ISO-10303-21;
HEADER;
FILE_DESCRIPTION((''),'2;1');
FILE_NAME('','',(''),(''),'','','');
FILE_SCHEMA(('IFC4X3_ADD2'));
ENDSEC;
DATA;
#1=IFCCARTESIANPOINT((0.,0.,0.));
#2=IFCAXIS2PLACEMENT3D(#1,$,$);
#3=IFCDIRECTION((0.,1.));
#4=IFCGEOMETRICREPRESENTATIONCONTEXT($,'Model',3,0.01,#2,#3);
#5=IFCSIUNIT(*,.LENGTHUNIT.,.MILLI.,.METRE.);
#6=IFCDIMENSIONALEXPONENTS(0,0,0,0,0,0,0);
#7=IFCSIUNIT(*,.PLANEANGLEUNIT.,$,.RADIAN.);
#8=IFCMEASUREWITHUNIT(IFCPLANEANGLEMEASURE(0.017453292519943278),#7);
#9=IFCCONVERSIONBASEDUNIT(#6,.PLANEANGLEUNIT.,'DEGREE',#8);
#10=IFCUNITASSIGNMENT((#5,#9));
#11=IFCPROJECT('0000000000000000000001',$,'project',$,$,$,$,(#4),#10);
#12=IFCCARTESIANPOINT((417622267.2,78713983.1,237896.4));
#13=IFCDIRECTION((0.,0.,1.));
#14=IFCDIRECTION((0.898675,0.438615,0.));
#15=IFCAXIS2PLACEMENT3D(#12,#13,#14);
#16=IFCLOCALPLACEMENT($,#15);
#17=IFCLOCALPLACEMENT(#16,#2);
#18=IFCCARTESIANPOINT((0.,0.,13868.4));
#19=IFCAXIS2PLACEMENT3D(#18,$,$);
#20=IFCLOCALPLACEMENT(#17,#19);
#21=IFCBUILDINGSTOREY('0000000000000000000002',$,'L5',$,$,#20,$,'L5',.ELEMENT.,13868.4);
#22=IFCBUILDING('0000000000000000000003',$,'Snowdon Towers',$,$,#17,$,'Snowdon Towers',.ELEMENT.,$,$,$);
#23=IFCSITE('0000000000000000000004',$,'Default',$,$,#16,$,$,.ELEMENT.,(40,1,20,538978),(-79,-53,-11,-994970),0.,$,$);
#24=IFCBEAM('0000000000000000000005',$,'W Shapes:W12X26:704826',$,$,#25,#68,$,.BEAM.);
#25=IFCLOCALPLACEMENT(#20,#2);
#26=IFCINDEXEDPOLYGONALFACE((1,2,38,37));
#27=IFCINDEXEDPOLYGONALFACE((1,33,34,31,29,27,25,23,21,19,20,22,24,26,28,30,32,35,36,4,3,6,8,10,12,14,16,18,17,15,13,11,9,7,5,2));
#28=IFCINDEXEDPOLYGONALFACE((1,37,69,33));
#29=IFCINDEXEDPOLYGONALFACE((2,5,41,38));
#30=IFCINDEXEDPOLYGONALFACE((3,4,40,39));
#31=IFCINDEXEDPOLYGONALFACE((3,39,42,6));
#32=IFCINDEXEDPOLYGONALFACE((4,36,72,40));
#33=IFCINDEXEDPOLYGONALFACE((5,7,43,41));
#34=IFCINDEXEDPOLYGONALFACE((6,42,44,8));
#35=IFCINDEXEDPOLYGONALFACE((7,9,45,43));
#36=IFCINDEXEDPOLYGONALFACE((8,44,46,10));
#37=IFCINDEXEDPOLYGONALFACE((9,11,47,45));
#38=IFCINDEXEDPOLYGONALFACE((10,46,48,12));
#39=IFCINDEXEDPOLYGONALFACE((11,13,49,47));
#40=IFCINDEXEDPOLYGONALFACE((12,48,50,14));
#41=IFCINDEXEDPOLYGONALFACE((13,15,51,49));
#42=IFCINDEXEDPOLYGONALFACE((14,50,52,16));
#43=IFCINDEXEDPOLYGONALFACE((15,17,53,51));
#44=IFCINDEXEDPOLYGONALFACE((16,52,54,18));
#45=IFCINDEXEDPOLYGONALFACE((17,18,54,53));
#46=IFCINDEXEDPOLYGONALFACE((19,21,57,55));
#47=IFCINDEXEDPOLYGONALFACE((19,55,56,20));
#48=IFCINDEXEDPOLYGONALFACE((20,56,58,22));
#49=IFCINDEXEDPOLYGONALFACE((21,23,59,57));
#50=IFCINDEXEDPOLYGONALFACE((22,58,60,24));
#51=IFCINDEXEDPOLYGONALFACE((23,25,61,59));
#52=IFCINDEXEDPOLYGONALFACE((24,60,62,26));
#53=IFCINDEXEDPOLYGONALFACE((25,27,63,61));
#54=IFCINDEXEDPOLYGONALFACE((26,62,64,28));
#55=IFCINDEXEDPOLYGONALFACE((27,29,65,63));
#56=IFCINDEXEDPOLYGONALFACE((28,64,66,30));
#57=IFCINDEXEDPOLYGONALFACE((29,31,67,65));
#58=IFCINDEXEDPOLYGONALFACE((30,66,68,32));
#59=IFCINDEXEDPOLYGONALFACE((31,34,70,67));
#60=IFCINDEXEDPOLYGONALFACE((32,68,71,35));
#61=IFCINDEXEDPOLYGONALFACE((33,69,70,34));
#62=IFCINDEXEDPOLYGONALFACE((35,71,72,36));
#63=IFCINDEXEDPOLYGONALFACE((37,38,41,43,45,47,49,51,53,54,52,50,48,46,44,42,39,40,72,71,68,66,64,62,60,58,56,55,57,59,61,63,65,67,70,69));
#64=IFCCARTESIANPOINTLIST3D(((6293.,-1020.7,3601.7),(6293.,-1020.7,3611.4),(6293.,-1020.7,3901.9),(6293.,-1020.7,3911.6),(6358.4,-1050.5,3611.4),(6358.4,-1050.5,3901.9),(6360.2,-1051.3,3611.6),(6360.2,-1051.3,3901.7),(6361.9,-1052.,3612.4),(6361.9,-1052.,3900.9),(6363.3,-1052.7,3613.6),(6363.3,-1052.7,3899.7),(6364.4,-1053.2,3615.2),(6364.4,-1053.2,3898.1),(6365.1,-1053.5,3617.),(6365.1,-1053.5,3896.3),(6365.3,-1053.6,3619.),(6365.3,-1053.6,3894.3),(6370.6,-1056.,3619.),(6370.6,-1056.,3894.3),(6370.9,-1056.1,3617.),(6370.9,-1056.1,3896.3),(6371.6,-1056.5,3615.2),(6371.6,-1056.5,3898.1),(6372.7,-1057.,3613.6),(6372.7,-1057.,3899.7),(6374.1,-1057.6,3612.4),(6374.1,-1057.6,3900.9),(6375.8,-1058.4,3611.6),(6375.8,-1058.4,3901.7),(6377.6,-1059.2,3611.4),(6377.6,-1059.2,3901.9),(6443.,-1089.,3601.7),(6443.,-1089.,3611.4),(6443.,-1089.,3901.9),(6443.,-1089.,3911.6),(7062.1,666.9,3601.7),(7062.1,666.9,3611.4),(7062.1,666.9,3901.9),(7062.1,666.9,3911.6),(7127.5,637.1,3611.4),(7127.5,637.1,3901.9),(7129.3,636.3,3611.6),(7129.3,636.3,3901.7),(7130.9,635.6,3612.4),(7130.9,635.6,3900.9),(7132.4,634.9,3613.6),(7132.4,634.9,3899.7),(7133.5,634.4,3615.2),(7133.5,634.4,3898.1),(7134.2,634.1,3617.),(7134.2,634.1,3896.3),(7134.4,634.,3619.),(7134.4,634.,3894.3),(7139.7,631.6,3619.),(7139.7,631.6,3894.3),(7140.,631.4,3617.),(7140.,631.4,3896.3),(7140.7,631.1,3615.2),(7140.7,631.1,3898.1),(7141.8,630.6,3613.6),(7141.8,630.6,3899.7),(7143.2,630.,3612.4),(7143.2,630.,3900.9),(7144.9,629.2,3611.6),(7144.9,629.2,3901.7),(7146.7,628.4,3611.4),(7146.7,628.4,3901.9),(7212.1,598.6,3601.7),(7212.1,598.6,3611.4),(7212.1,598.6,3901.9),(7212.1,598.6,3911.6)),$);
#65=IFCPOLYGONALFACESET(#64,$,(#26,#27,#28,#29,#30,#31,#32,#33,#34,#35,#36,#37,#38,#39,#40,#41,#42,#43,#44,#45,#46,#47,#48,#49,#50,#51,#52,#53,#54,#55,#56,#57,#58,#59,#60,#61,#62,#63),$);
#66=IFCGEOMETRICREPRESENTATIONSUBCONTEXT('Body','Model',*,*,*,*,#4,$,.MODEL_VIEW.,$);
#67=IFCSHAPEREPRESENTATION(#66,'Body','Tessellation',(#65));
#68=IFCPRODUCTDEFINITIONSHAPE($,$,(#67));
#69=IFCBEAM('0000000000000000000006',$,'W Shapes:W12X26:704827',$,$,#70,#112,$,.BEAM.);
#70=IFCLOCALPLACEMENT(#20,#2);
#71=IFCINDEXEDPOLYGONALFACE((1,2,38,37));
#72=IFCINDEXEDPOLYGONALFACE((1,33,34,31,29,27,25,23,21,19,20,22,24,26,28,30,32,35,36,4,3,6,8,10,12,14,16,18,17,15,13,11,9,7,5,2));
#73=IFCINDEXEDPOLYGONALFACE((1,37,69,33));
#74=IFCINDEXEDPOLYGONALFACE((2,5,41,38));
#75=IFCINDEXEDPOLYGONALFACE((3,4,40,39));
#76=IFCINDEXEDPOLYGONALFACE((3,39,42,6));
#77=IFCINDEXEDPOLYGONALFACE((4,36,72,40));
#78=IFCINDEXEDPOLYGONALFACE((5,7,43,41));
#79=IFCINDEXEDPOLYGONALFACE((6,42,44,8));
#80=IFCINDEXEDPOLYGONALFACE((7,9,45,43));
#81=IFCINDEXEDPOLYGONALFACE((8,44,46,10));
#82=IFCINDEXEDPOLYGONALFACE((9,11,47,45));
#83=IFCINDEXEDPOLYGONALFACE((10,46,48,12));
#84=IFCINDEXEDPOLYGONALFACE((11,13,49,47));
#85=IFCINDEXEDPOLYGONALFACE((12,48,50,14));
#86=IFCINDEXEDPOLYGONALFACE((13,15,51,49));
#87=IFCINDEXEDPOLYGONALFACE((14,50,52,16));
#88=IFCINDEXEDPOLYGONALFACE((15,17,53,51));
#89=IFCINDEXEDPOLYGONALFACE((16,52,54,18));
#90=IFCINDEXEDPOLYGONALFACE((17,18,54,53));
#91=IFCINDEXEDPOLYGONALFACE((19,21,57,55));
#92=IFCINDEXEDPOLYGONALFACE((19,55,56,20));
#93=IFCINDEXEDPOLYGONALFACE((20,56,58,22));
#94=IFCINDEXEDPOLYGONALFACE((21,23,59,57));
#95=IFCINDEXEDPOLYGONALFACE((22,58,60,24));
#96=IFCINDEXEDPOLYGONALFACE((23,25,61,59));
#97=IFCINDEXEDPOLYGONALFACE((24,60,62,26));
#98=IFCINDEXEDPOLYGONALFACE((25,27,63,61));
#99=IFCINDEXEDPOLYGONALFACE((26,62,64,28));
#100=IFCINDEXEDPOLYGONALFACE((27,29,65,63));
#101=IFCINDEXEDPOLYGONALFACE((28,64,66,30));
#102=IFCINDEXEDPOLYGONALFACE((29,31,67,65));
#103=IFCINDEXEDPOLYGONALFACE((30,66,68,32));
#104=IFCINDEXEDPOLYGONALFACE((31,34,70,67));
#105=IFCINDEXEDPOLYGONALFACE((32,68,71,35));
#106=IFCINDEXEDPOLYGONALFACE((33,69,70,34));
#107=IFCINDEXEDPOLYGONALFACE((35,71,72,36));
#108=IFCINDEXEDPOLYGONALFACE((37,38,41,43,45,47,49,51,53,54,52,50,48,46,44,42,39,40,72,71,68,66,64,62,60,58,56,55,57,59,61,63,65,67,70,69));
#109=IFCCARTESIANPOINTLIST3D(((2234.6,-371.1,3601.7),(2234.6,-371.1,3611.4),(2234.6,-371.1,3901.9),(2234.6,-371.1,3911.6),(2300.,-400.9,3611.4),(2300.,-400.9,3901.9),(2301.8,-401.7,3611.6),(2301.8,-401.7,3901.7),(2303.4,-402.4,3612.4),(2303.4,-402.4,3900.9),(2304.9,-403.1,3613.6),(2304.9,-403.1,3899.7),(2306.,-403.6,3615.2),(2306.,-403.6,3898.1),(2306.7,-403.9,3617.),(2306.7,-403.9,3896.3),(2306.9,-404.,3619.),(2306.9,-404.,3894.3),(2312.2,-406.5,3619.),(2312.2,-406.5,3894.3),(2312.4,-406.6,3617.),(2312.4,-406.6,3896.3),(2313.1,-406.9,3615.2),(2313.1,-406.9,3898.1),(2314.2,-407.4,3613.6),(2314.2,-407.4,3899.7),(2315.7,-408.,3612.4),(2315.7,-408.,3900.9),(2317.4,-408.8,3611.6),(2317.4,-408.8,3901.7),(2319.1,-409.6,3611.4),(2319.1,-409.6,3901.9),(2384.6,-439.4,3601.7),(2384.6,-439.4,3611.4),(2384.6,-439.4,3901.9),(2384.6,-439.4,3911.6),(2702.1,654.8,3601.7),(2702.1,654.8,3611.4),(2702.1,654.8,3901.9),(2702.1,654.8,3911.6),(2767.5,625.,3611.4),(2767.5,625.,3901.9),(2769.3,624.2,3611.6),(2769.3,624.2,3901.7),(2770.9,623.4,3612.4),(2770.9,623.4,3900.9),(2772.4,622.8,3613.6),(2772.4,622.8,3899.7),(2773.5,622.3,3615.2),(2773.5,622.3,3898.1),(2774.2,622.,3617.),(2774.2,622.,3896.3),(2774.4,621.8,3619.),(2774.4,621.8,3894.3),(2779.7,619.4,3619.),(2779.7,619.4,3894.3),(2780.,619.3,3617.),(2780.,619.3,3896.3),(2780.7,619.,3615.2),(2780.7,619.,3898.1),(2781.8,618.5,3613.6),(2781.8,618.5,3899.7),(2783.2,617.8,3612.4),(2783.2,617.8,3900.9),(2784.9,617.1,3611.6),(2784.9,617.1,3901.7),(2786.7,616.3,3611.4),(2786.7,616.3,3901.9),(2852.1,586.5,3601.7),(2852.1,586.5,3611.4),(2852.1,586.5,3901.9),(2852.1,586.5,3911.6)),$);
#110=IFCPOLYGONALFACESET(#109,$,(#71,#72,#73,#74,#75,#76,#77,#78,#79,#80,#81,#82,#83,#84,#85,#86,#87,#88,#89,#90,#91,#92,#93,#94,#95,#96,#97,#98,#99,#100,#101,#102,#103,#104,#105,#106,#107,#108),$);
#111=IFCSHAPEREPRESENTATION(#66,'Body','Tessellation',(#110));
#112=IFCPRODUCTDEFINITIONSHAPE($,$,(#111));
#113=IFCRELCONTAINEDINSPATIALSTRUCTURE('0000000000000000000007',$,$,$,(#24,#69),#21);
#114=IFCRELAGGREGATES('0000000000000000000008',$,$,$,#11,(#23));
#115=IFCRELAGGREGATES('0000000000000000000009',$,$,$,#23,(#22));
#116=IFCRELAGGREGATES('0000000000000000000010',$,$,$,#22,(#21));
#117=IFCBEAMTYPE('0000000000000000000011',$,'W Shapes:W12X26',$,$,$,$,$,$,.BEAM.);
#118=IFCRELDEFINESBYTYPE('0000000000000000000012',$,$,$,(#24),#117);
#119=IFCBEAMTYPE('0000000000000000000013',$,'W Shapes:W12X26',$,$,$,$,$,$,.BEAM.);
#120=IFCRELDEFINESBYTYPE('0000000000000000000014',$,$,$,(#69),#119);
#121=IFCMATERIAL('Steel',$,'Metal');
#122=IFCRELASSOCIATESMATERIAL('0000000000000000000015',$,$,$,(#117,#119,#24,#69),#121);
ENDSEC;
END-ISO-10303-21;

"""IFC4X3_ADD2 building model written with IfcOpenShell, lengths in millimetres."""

from ifc_helpers import new_model, entity, si_unit, converted_unit, direction, frame, frame_2d, origin, place, context, subcontext, project, spatial, polyline, circle_curve, parameter, trimmed, segment, composite_curve, outline, extrude, source, transform, mapped, material, material_profile, profile_set, profile_usage, type_object, type_shapes, element, save


model = new_model("IFC4X3_ADD2")

# Units and contexts
model_context = context("Model", 3, precision=0.01, world=origin(), true_north=direction((0.0, 1.0)))
body_context = subcontext(model_context, "Body", "Model", "MODEL_VIEW")
ifc_project = project(units=[si_unit("LENGTHUNIT", "METRE", prefix="MILLI"), converted_unit("PLANEANGLEUNIT", "DEGREE", entity("IfcPlaneAngleMeasure", 0.017453292519943278), si_unit("PLANEANGLEUNIT", "RADIAN"), dimensions=[0, 0, 0, 0, 0, 0, 0])], contexts=[model_context])

# Site, building, storey
site_placement = place(None, frame((417622267.2, 78713983.1, 237896.4), z_axis=(0.0, 0.0, 1.0), x_axis=(0.898675, 0.438615, 0.0)))
site = spatial("IfcSite", under=ifc_project, at=site_placement, Name="Default", CompositionType="ELEMENT", RefLatitude=(40, 1, 20, 538978), RefLongitude=(-79, -53, -11, -994970), RefElevation=0.0)
building_placement = place(site_placement, origin())
building = spatial("IfcBuilding", under=site, at=building_placement, Name="Snowdon Towers", LongName="Snowdon Towers", CompositionType="ELEMENT")
storey_placement = place(building_placement, frame((0.0, 0.0, 13868.4)))
storey = spatial("IfcBuildingStorey", under=building, at=storey_placement, Name="L5", LongName="L5", CompositionType="ELEMENT", Elevation=13868.4)

# Shared definitions
ifc_material_1 = material(Name="Steel", Category="Metal")

# Beams
ifc_material_profile_1 = material_profile(ifc_material_1, outline(composite_curve([segment(polyline([(-82.4, -145.3), (-82.4, -154.9)]), True, "CONTINUOUS"), segment(polyline([(-82.4, -154.9), (82.4, -154.9)]), True, "CONTINUOUS"), segment(polyline([(82.4, -154.9), (82.4, -145.3)]), True, "CONTINUOUS"), segment(polyline([(82.4, -145.3), (10.5, -145.3)]), True, "CONTINUOUS"), segment(trimmed(circle_curve(frame_2d((10.5, -137.7), x_axis=(1.0, 0.0)), 7.6), [parameter(180.0)], [parameter(270.0)], True, "PARAMETER"), False, "CONTINUOUS"), segment(polyline([(2.9, -137.7), (2.9, 137.7)]), True, "CONTINUOUS"), segment(trimmed(circle_curve(frame_2d((10.5, 137.7), x_axis=(1.0, 0.0)), 7.6), [parameter(90.0)], [parameter(180.0)], True, "PARAMETER"), False, "CONTINUOUS"), segment(polyline([(10.5, 145.3), (82.4, 145.3)]), True, "CONTINUOUS"), segment(polyline([(82.4, 145.3), (82.4, 154.9)]), True, "CONTINUOUS"), segment(polyline([(82.4, 154.9), (-82.4, 154.9)]), True, "CONTINUOUS"), segment(polyline([(-82.4, 154.9), (-82.4, 145.3)]), True, "CONTINUOUS"), segment(polyline([(-82.4, 145.3), (-10.5, 145.3)]), True, "CONTINUOUS"), segment(trimmed(circle_curve(frame_2d((-10.5, 137.7), x_axis=(1.0, 0.0)), 7.6), [parameter(360.0)], [parameter(90.0)], True, "PARAMETER"), False, "CONTINUOUS"), segment(polyline([(-2.9, 137.7), (-2.9, -137.7)]), True, "CONTINUOUS"), segment(trimmed(circle_curve(frame_2d((-10.5, -137.7), x_axis=(1.0, 0.0)), 7.6), [parameter(270.0)], [parameter(360.0)], True, "PARAMETER"), False, "CONTINUOUS"), segment(polyline([(-10.5, -145.3), (-82.4, -145.3)]), True, "CONTINUOUS")], self_intersect=False)), Name="W12X26")
ifc_profile_set_1 = profile_set([ifc_material_profile_1], Name="W12X26")
ifc_profile_usage_1 = profile_usage(ifc_profile_set_1, cardinal=8)
beam_type_1 = type_object("IfcBeamType", Name="W Shapes:W12X26", PredefinedType="BEAM", material=ifc_profile_set_1)
shared_shape_1 = source(origin(), body_context, "Body", "SweptSolid", [
    extrude(outline(composite_curve([segment(polyline([(-82.4, -145.3), (-82.4, -154.9)]), True, "CONTINUOUS"), segment(polyline([(-82.4, -154.9), (82.4, -154.9)]), True, "CONTINUOUS"), segment(polyline([(82.4, -154.9), (82.4, -145.3)]), True, "CONTINUOUS"), segment(polyline([(82.4, -145.3), (10.5, -145.3)]), True, "CONTINUOUS"), segment(trimmed(circle_curve(frame_2d((10.5, -137.7), x_axis=(1.0, 0.0)), 7.6), [parameter(180.0)], [parameter(270.0)], True, "PARAMETER"), False, "CONTINUOUS"), segment(polyline([(2.9, -137.7), (2.9, 137.7)]), True, "CONTINUOUS"), segment(trimmed(circle_curve(frame_2d((10.5, 137.7), x_axis=(1.0, 0.0)), 7.6), [parameter(90.0)], [parameter(180.0)], True, "PARAMETER"), False, "CONTINUOUS"), segment(polyline([(10.5, 145.3), (82.4, 145.3)]), True, "CONTINUOUS"), segment(polyline([(82.4, 145.3), (82.4, 154.9)]), True, "CONTINUOUS"), segment(polyline([(82.4, 154.9), (-82.4, 154.9)]), True, "CONTINUOUS"), segment(polyline([(-82.4, 154.9), (-82.4, 145.3)]), True, "CONTINUOUS"), segment(polyline([(-82.4, 145.3), (-10.5, 145.3)]), True, "CONTINUOUS"), segment(trimmed(circle_curve(frame_2d((-10.5, 137.7), x_axis=(1.0, 0.0)), 7.6), [parameter(360.0)], [parameter(90.0)], True, "PARAMETER"), False, "CONTINUOUS"), segment(polyline([(-2.9, 137.7), (-2.9, -137.7)]), True, "CONTINUOUS"), segment(trimmed(circle_curve(frame_2d((-10.5, -137.7), x_axis=(1.0, 0.0)), 7.6), [parameter(270.0)], [parameter(360.0)], True, "PARAMETER"), False, "CONTINUOUS"), segment(polyline([(-10.5, -145.3), (-82.4, -145.3)]), True, "CONTINUOUS")], self_intersect=False)), frame((-941.2, 0.0, 0.0), z_axis=(-1.0, 0.0, 0.0), x_axis=(0.0, -1.0, 0.0)), (0.0, 0.0, -1.0), 1854.6),
])
type_shapes(beam_type_1, [shared_shape_1])
beam_1_placement = place(storey_placement, frame((6758.3, -198.4, 3756.7), z_axis=(0.0, 0.0, 1.0), x_axis=(0.414693, 0.909961, 0.0)))
element("IfcBeam", 1, at=beam_1_placement, inside=storey, type_object=beam_type_1, material=ifc_profile_usage_1, Name="W Shapes:W12X26:704826", PredefinedType="BEAM", context=body_context, shape_type="MappedRepresentation", body=[
    mapped(shared_shape_1, transform((0.0, 0.0, 0.0), scale=1.0)),
])
beam_type_2 = type_object("IfcBeamType", Name="W Shapes:W12X26", PredefinedType="BEAM", material=ifc_profile_set_1)
shared_shape_2 = source(origin(), body_context, "Body", "SweptSolid", [
    extrude(outline(composite_curve([segment(polyline([(145.3, -82.4), (154.9, -82.4)]), True, "CONTINUOUS"), segment(polyline([(154.9, -82.4), (154.9, 82.4)]), True, "CONTINUOUS"), segment(polyline([(154.9, 82.4), (145.3, 82.4)]), True, "CONTINUOUS"), segment(polyline([(145.3, 82.4), (145.3, 10.5)]), True, "CONTINUOUS"), segment(trimmed(circle_curve(frame_2d((137.7, 10.5), x_axis=(1.0, 0.0)), 7.6), [parameter(270.0)], [parameter(0.0)], True, "PARAMETER"), False, "CONTINUOUS"), segment(polyline([(137.7, 2.9), (-137.7, 2.9)]), True, "CONTINUOUS"), segment(trimmed(circle_curve(frame_2d((-137.7, 10.5), x_axis=(0.0, -1.0)), 7.6), [parameter(270.0)], [parameter(0.0)], True, "PARAMETER"), False, "CONTINUOUS"), segment(polyline([(-145.3, 10.5), (-145.3, 82.4)]), True, "CONTINUOUS"), segment(polyline([(-145.3, 82.4), (-154.9, 82.4)]), True, "CONTINUOUS"), segment(polyline([(-154.9, 82.4), (-154.9, -82.4)]), True, "CONTINUOUS"), segment(polyline([(-154.9, -82.4), (-145.3, -82.4)]), True, "CONTINUOUS"), segment(polyline([(-145.3, -82.4), (-145.3, -10.5)]), True, "CONTINUOUS"), segment(trimmed(circle_curve(frame_2d((-137.7, -10.5), x_axis=(-1.0, 0.0)), 7.6), [parameter(270.0)], [parameter(0.0)], True, "PARAMETER"), False, "CONTINUOUS"), segment(polyline([(-137.7, -2.9), (137.7, -2.9)]), True, "CONTINUOUS"), segment(trimmed(circle_curve(frame_2d((137.7, -10.5), x_axis=(0.0, 1.0)), 7.6), [parameter(270.0)], [parameter(0.0)], True, "PARAMETER"), False, "CONTINUOUS"), segment(polyline([(145.3, -10.5), (145.3, -82.4)]), True, "CONTINUOUS")], self_intersect=False)), frame((2309.6, -405.2, 17625.1), z_axis=(0.414693, 0.909961, 0.0), x_axis=(0.0, 0.0, 1.0)), (0.0, 0.0, 1.0), 1127.4),
])
type_shapes(beam_type_2, [shared_shape_2])
beam_2_placement = place(storey_placement, frame((0.0, 0.0, -13868.4)))
element("IfcBeam", 2, at=beam_2_placement, inside=storey, type_object=beam_type_2, material=ifc_profile_usage_1, Name="W Shapes:W12X26:704827", PredefinedType="BEAM", context=body_context, shape_type="MappedRepresentation", body=[
    mapped(shared_shape_2, transform((0.0, 0.0, 0.0), scale=1.0)),
])

save(model, "model.ifc")
